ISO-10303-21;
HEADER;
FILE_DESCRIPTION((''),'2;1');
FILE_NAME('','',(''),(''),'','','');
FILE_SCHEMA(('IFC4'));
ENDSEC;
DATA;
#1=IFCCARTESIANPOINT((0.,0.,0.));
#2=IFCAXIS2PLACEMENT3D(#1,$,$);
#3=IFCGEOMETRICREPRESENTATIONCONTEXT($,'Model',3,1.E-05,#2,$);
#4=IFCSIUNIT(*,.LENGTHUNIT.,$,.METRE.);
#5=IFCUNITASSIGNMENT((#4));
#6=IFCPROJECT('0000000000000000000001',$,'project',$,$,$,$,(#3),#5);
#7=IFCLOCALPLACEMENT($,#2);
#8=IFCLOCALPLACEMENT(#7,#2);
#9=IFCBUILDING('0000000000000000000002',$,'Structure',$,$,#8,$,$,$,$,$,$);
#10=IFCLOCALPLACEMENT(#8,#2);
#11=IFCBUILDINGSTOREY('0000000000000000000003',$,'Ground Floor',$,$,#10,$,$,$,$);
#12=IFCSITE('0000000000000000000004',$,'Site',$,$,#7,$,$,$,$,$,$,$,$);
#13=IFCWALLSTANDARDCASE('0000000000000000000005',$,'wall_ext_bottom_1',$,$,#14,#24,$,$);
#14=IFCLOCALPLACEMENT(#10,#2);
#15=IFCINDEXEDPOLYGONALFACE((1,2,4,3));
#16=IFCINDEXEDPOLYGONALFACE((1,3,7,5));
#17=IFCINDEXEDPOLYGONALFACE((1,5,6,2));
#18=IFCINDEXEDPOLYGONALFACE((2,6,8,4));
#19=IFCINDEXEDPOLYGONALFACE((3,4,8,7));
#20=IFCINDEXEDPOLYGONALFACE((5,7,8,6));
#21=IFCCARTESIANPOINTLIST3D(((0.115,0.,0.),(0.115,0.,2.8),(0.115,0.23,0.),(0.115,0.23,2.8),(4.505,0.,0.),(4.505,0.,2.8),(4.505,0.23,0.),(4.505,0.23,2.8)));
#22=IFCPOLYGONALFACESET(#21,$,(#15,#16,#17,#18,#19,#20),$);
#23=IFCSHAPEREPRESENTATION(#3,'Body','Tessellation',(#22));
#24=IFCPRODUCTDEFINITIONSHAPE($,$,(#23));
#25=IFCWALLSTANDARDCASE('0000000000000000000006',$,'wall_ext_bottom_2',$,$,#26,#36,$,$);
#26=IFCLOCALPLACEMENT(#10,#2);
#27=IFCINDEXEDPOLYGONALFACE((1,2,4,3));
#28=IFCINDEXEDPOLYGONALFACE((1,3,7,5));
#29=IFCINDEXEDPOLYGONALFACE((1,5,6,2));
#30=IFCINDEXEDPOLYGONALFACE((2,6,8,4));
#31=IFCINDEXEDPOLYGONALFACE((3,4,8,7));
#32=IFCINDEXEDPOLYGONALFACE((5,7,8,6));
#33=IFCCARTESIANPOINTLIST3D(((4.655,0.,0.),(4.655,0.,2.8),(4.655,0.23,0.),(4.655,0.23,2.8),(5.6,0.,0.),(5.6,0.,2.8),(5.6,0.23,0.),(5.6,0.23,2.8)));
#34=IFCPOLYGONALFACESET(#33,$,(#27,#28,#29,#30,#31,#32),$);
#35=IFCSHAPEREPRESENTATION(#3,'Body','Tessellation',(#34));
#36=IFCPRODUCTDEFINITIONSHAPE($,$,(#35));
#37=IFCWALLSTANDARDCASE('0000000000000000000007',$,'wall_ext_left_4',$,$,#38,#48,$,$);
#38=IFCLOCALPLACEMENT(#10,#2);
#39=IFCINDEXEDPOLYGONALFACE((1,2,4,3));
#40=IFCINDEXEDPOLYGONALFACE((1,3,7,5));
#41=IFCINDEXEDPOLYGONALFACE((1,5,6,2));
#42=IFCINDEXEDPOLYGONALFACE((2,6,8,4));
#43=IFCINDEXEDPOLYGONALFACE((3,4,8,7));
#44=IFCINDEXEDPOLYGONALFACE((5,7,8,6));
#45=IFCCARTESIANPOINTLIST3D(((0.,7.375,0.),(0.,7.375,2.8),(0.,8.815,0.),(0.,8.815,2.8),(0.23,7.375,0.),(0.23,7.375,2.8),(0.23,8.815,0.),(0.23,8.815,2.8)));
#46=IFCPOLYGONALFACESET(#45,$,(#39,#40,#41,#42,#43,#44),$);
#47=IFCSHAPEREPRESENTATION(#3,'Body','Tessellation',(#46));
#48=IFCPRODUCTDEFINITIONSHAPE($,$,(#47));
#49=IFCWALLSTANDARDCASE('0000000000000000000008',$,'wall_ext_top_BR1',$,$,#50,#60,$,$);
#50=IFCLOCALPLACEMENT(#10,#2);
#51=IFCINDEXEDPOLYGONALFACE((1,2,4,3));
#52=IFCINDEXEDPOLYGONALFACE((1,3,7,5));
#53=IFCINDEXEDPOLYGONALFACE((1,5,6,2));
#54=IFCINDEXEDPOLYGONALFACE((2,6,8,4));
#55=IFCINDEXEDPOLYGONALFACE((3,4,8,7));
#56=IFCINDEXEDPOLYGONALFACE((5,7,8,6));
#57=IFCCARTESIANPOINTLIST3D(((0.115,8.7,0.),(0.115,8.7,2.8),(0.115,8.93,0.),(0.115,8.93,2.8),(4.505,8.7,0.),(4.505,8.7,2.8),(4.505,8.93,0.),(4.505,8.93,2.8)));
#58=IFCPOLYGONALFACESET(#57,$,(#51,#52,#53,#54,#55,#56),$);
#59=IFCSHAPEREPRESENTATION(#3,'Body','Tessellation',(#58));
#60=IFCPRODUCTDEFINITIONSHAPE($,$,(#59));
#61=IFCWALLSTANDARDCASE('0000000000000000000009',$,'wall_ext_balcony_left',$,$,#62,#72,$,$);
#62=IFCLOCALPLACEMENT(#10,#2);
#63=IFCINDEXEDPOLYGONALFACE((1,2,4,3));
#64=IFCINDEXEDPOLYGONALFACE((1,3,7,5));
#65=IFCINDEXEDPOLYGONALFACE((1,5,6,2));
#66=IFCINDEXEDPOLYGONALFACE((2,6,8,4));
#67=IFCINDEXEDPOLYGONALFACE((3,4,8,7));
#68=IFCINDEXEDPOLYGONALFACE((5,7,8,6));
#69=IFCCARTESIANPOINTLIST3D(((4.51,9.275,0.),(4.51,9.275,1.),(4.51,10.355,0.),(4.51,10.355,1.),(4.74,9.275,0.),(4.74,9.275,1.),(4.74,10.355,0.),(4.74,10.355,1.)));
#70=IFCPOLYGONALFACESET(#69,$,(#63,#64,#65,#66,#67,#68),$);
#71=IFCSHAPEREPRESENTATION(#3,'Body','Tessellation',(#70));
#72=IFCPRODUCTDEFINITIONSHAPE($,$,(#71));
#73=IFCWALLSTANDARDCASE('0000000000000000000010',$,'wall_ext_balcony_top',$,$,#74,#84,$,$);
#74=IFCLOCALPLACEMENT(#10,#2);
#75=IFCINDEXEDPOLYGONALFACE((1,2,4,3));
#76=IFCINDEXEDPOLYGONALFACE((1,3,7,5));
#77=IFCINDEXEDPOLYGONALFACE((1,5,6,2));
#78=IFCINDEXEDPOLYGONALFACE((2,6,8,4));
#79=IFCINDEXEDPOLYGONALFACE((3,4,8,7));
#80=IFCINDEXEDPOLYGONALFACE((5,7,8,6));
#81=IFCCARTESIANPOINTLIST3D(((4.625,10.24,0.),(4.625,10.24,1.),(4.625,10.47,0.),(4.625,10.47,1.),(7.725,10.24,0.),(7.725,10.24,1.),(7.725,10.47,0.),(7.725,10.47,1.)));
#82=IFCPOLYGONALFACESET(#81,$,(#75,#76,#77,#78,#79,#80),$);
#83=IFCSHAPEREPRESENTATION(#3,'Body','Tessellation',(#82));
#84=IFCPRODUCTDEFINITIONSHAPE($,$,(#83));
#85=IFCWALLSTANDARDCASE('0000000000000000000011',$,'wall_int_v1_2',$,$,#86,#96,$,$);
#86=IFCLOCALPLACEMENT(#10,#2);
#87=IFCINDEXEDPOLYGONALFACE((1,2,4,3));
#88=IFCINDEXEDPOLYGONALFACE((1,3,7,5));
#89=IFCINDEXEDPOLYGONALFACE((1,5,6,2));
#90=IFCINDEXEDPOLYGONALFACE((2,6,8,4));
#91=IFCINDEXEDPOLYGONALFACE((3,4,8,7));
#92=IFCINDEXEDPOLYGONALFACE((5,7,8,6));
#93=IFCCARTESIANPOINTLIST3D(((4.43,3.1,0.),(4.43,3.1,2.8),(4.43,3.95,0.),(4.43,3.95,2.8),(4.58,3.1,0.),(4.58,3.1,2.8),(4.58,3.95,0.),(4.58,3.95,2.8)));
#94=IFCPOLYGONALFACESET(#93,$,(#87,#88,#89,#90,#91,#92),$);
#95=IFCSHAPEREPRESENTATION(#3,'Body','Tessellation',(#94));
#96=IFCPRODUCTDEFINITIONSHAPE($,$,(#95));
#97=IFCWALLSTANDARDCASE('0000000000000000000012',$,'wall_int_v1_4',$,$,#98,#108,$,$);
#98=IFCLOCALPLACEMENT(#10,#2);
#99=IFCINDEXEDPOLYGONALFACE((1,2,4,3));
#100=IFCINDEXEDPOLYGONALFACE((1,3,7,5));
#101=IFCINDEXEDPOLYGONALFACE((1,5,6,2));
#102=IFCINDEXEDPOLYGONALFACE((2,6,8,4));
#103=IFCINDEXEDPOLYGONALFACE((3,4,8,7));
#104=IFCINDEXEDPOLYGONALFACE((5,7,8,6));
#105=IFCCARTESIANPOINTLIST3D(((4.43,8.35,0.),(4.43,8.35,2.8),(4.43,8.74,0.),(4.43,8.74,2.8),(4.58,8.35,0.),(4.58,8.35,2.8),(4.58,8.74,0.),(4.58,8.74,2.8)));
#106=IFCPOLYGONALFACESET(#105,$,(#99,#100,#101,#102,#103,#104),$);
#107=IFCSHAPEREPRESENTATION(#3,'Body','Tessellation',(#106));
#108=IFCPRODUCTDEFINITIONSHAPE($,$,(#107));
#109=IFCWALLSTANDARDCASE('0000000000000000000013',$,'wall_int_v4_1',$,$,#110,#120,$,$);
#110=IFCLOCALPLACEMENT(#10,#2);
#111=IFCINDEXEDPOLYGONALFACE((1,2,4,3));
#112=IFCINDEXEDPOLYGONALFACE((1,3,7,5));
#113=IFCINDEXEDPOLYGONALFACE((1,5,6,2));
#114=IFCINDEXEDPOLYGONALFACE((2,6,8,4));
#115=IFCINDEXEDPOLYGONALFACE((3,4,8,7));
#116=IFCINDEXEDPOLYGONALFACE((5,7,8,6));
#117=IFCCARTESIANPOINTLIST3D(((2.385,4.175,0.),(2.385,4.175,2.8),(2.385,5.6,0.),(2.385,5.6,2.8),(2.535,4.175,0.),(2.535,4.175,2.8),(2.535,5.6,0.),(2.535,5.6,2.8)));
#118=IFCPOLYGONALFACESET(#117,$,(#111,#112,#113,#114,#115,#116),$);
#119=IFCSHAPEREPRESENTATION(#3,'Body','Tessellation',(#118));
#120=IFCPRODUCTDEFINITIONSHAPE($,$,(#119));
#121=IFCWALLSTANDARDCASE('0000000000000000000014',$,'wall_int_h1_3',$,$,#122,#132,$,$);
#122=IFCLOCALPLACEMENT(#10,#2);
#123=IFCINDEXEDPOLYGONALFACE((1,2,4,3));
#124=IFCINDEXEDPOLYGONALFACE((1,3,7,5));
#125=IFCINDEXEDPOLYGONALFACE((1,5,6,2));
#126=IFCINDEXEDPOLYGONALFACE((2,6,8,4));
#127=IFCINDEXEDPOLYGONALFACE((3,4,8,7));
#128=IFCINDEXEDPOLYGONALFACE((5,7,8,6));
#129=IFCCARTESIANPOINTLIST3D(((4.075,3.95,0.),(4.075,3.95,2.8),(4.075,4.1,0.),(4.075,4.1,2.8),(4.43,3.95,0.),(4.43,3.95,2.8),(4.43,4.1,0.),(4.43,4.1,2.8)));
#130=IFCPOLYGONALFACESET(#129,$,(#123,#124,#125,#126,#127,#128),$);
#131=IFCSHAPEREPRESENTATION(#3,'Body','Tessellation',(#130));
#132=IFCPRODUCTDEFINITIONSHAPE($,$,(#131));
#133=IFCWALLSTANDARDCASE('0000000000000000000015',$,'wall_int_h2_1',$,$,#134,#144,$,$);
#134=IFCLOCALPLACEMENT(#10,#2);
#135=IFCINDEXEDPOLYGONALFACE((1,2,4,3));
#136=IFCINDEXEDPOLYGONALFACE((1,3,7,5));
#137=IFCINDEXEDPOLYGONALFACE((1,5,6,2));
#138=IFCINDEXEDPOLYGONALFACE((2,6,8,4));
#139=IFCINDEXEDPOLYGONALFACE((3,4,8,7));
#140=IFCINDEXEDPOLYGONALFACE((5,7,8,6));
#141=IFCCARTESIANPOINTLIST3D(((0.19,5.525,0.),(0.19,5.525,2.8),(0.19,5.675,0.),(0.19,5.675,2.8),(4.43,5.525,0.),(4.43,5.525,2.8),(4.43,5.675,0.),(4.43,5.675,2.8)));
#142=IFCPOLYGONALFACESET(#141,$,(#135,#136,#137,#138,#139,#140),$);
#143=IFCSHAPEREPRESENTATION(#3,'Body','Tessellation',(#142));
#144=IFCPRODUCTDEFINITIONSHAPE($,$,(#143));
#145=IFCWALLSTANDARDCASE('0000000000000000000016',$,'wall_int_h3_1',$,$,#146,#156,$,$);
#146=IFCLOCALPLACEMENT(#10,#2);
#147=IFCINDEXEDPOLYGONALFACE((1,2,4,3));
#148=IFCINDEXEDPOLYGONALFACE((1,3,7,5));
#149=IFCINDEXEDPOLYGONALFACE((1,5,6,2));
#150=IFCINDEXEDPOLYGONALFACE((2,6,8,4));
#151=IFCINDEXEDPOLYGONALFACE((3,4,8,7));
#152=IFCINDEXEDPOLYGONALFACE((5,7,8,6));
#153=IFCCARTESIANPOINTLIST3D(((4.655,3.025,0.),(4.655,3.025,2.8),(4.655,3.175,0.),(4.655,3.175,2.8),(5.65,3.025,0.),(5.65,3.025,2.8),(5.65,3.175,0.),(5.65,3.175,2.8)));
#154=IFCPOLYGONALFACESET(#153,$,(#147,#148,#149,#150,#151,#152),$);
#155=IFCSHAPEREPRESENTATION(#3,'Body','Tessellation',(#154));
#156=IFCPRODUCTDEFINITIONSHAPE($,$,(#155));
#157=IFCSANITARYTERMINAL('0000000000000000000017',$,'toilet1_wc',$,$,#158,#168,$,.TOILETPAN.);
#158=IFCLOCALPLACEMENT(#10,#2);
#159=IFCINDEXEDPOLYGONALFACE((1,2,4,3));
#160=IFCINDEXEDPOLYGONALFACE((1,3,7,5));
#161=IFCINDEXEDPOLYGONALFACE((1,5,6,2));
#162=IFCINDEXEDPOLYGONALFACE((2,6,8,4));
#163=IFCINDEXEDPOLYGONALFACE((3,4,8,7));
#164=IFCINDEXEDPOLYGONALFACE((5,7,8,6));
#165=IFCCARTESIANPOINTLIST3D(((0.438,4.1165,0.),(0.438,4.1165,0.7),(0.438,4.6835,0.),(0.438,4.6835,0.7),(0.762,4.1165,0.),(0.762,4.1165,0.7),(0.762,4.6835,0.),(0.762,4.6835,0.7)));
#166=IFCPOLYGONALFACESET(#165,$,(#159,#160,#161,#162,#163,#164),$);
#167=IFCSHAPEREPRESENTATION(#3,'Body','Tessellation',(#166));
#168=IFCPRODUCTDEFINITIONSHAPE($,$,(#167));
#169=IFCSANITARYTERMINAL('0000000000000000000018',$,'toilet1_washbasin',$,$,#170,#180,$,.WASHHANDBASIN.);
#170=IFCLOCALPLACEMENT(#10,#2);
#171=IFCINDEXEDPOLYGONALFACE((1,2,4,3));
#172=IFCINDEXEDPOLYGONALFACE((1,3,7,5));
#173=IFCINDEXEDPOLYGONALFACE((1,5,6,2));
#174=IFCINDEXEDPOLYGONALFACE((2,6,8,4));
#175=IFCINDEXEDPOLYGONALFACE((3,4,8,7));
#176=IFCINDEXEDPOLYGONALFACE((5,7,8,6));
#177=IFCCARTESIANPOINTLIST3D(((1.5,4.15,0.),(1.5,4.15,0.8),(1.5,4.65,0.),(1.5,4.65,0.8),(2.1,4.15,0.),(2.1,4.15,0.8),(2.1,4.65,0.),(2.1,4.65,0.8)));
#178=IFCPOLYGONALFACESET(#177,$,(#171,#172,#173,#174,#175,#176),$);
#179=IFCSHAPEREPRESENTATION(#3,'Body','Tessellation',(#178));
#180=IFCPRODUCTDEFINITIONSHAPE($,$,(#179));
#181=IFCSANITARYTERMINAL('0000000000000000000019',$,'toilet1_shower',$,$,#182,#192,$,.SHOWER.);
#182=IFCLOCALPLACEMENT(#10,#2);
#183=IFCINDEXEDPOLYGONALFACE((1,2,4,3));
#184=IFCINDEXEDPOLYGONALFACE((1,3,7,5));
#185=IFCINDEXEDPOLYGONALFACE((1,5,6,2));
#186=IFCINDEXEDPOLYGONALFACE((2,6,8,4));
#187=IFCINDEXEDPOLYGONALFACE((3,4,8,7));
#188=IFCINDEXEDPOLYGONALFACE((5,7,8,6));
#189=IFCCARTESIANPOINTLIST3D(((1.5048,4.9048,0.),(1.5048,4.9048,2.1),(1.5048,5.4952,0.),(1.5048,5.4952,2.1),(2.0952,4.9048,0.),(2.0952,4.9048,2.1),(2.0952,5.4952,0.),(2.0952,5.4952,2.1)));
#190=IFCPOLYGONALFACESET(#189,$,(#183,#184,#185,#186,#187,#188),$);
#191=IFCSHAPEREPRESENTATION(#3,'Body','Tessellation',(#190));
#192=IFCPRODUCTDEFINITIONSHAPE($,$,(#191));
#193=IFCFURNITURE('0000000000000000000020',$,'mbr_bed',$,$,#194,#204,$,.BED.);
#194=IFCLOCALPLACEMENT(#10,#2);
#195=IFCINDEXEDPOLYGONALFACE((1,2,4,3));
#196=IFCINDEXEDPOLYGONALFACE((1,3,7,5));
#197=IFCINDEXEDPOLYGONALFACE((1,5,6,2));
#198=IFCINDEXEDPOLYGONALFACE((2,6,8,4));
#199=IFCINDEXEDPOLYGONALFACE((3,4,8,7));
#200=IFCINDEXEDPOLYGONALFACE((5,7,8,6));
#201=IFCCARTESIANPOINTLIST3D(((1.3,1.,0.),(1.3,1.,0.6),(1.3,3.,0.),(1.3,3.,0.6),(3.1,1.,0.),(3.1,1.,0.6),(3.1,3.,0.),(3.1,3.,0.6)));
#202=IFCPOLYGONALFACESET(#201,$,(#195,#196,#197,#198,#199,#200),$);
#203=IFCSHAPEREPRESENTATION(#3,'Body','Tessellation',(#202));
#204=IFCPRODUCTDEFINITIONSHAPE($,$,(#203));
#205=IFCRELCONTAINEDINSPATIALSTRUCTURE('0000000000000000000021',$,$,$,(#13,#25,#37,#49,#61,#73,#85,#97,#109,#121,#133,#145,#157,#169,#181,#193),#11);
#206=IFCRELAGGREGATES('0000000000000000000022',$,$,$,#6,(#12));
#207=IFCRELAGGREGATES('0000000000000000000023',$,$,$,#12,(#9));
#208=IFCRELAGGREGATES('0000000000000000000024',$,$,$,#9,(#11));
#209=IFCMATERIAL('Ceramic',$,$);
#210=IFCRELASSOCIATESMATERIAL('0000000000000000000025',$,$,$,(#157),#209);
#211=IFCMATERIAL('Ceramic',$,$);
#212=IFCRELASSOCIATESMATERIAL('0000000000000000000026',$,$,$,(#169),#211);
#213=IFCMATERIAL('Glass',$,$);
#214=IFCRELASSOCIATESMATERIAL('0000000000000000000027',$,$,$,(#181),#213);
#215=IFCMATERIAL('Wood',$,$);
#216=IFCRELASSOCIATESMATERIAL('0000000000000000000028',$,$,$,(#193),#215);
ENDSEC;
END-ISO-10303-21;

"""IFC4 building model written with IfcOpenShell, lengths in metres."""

from ifc_helpers import new_model, si_unit, frame, origin, place, context, project, spatial, polyline, outline, extrude, material, element, save


model = new_model("IFC4")

# Units and contexts
model_context = context("Model", 3, precision=1e-05, world=origin())
ifc_project = project(units=[si_unit("LENGTHUNIT", "METRE")], contexts=[model_context])

# Site, building, storey
site_placement = place(None, origin())
site = spatial("IfcSite", under=ifc_project, at=site_placement, Name="Site")
building_placement = place(site_placement, origin())
building = spatial("IfcBuilding", under=site, at=building_placement, Name="Structure")
storey_placement = place(building_placement, origin())
storey = spatial("IfcBuildingStorey", under=building, at=storey_placement, Name="Ground Floor")

# Walls
wall_1_placement = place(storey_placement, frame((0.115, 0.115, 0.0), x_axis=(1.0, 0.0, 0.0)))
element("IfcWallStandardCase", 1, at=wall_1_placement, inside=storey, Name="wall_ext_bottom_1", context=model_context, shape_type="SweptSolid", body=[
    extrude(outline(polyline([(0.0, -0.115), (4.39, -0.115), (4.39, 0.115), (0.0, 0.115), (0.0, -0.115)])), origin(), (0.0, 0.0, 1.0), 2.8),
])
wall_2_placement = place(storey_placement, frame((4.655, 0.115, 0.0), x_axis=(1.0, 0.0, 0.0)))
element("IfcWallStandardCase", 2, at=wall_2_placement, inside=storey, Name="wall_ext_bottom_2", context=model_context, shape_type="SweptSolid", body=[
    extrude(outline(polyline([(0.0, -0.115), (0.945, -0.115), (0.945, 0.115), (0.0, 0.115), (0.0, -0.115)])), origin(), (0.0, 0.0, 1.0), 2.8),
])
wall_3_placement = place(storey_placement, frame((0.115, 7.375, 0.0), x_axis=(0.0, 1.0, 0.0)))
element("IfcWallStandardCase", 3, at=wall_3_placement, inside=storey, Name="wall_ext_left_4", context=model_context, shape_type="SweptSolid", body=[
    extrude(outline(polyline([(0.0, -0.115), (1.44, -0.115), (1.44, 0.115), (0.0, 0.115), (0.0, -0.115)])), origin(), (0.0, 0.0, 1.0), 2.8),
])
wall_4_placement = place(storey_placement, frame((0.115, 8.815, 0.0), x_axis=(1.0, 0.0, 0.0)))
element("IfcWallStandardCase", 4, at=wall_4_placement, inside=storey, Name="wall_ext_top_BR1", context=model_context, shape_type="SweptSolid", body=[
    extrude(outline(polyline([(0.0, -0.115), (4.39, -0.115), (4.39, 0.115), (0.0, 0.115), (0.0, -0.115)])), origin(), (0.0, 0.0, 1.0), 2.8),
])
wall_5_placement = place(storey_placement, frame((4.625, 9.275, 0.0), x_axis=(0.0, 1.0, 0.0)))
element("IfcWallStandardCase", 5, at=wall_5_placement, inside=storey, Name="wall_ext_balcony_left", context=model_context, shape_type="SweptSolid", body=[
    extrude(outline(polyline([(0.0, -0.115), (1.08, -0.115), (1.08, 0.115), (0.0, 0.115), (0.0, -0.115)])), origin(), (0.0, 0.0, 1.0), 1.0),
])
wall_6_placement = place(storey_placement, frame((4.625, 10.355, 0.0), x_axis=(1.0, 0.0, 0.0)))
element("IfcWallStandardCase", 6, at=wall_6_placement, inside=storey, Name="wall_ext_balcony_top", context=model_context, shape_type="SweptSolid", body=[
    extrude(outline(polyline([(0.0, -0.115), (3.1, -0.115), (3.1, 0.115), (0.0, 0.115), (0.0, -0.115)])), origin(), (0.0, 0.0, 1.0), 1.0),
])
wall_7_placement = place(storey_placement, frame((4.505, 3.1, 0.0), x_axis=(0.0, 1.0, 0.0)))
element("IfcWallStandardCase", 7, at=wall_7_placement, inside=storey, Name="wall_int_v1_2", context=model_context, shape_type="SweptSolid", body=[
    extrude(outline(polyline([(0.0, -0.075), (0.85, -0.075), (0.85, 0.075), (0.0, 0.075), (0.0, -0.075)])), origin(), (0.0, 0.0, 1.0), 2.8),
])
wall_8_placement = place(storey_placement, frame((4.505, 8.35, 0.0), x_axis=(0.0, 1.0, 0.0)))
element("IfcWallStandardCase", 8, at=wall_8_placement, inside=storey, Name="wall_int_v1_4", context=model_context, shape_type="SweptSolid", body=[
    extrude(outline(polyline([(0.0, -0.075), (0.39, -0.075), (0.39, 0.075), (0.0, 0.075), (0.0, -0.075)])), origin(), (0.0, 0.0, 1.0), 2.8),
])
wall_9_placement = place(storey_placement, frame((2.46, 4.175, 0.0), x_axis=(0.0, 1.0, 0.0)))
element("IfcWallStandardCase", 9, at=wall_9_placement, inside=storey, Name="wall_int_v4_1", context=model_context, shape_type="SweptSolid", body=[
    extrude(outline(polyline([(0.0, -0.075), (1.425, -0.075), (1.425, 0.075), (0.0, 0.075), (0.0, -0.075)])), origin(), (0.0, 0.0, 1.0), 2.8),
])
wall_10_placement = place(storey_placement, frame((4.075, 4.025, 0.0), x_axis=(1.0, 0.0, 0.0)))
element("IfcWallStandardCase", 10, at=wall_10_placement, inside=storey, Name="wall_int_h1_3", context=model_context, shape_type="SweptSolid", body=[
    extrude(outline(polyline([(0.0, -0.075), (0.355, -0.075), (0.355, 0.075), (0.0, 0.075), (0.0, -0.075)])), origin(), (0.0, 0.0, 1.0), 2.8),
])
wall_11_placement = place(storey_placement, frame((0.19, 5.6, 0.0), x_axis=(1.0, 0.0, 0.0)))
element("IfcWallStandardCase", 11, at=wall_11_placement, inside=storey, Name="wall_int_h2_1", context=model_context, shape_type="SweptSolid", body=[
    extrude(outline(polyline([(0.0, -0.075), (4.24, -0.075), (4.24, 0.075), (0.0, 0.075), (0.0, -0.075)])), origin(), (0.0, 0.0, 1.0), 2.8),
])
wall_12_placement = place(storey_placement, frame((4.655, 3.1, 0.0), x_axis=(1.0, 0.0, 0.0)))
element("IfcWallStandardCase", 12, at=wall_12_placement, inside=storey, Name="wall_int_h3_1", context=model_context, shape_type="SweptSolid", body=[
    extrude(outline(polyline([(0.0, -0.075), (0.995, -0.075), (0.995, 0.075), (0.0, 0.075), (0.0, -0.075)])), origin(), (0.0, 0.0, 1.0), 2.8),
])

# Sanitary terminals
ifc_material_1 = material(Name="Ceramic")
sanitary_terminal_1_placement = place(storey_placement, frame((0.6, 4.4, 0.0)))
element("IfcSanitaryTerminal", 13, at=sanitary_terminal_1_placement, inside=storey, material=ifc_material_1, Name="toilet1_wc", PredefinedType="TOILETPAN", context=model_context, shape_type="SweptSolid", body=[
    extrude(outline(polyline([(-0.162, -0.2835), (0.162, -0.2835), (0.162, 0.2835), (-0.162, 0.2835), (-0.162, -0.2835)])), origin(), (0.0, 0.0, 1.0), 0.7),
])
ifc_material_2 = material(Name="Ceramic")
sanitary_terminal_2_placement = place(storey_placement, frame((1.8, 4.4, 0.0)))
element("IfcSanitaryTerminal", 14, at=sanitary_terminal_2_placement, inside=storey, material=ifc_material_2, Name="toilet1_washbasin", PredefinedType="WASHHANDBASIN", context=model_context, shape_type="SweptSolid", body=[
    extrude(outline(polyline([(-0.3, -0.25), (0.3, -0.25), (0.3, 0.25), (-0.3, 0.25), (-0.3, -0.25)])), origin(), (0.0, 0.0, 1.0), 0.8),
])
ifc_material_3 = material(Name="Glass")
sanitary_terminal_3_placement = place(storey_placement, frame((1.8, 5.2, 0.0)))
element("IfcSanitaryTerminal", 15, at=sanitary_terminal_3_placement, inside=storey, material=ifc_material_3, Name="toilet1_shower", PredefinedType="SHOWER", context=model_context, shape_type="SweptSolid", body=[
    extrude(outline(polyline([(-0.2952, -0.2952), (0.2952, -0.2952), (0.2952, 0.2952), (-0.2952, 0.2952), (-0.2952, -0.2952)])), origin(), (0.0, 0.0, 1.0), 2.1),
])

# Furniture
ifc_material_4 = material(Name="Wood")
furniture_1_placement = place(storey_placement, frame((2.2, 2.0, 0.0)))
element("IfcFurniture", 16, at=furniture_1_placement, inside=storey, material=ifc_material_4, Name="mbr_bed", PredefinedType="BED", context=model_context, shape_type="SweptSolid", body=[
    extrude(outline(polyline([(-0.9, -1.0), (0.9, -1.0), (0.9, 1.0), (-0.9, 1.0), (-0.9, -1.0)])), origin(), (0.0, 0.0, 1.0), 0.6),
])

save(model, "model.ifc")
